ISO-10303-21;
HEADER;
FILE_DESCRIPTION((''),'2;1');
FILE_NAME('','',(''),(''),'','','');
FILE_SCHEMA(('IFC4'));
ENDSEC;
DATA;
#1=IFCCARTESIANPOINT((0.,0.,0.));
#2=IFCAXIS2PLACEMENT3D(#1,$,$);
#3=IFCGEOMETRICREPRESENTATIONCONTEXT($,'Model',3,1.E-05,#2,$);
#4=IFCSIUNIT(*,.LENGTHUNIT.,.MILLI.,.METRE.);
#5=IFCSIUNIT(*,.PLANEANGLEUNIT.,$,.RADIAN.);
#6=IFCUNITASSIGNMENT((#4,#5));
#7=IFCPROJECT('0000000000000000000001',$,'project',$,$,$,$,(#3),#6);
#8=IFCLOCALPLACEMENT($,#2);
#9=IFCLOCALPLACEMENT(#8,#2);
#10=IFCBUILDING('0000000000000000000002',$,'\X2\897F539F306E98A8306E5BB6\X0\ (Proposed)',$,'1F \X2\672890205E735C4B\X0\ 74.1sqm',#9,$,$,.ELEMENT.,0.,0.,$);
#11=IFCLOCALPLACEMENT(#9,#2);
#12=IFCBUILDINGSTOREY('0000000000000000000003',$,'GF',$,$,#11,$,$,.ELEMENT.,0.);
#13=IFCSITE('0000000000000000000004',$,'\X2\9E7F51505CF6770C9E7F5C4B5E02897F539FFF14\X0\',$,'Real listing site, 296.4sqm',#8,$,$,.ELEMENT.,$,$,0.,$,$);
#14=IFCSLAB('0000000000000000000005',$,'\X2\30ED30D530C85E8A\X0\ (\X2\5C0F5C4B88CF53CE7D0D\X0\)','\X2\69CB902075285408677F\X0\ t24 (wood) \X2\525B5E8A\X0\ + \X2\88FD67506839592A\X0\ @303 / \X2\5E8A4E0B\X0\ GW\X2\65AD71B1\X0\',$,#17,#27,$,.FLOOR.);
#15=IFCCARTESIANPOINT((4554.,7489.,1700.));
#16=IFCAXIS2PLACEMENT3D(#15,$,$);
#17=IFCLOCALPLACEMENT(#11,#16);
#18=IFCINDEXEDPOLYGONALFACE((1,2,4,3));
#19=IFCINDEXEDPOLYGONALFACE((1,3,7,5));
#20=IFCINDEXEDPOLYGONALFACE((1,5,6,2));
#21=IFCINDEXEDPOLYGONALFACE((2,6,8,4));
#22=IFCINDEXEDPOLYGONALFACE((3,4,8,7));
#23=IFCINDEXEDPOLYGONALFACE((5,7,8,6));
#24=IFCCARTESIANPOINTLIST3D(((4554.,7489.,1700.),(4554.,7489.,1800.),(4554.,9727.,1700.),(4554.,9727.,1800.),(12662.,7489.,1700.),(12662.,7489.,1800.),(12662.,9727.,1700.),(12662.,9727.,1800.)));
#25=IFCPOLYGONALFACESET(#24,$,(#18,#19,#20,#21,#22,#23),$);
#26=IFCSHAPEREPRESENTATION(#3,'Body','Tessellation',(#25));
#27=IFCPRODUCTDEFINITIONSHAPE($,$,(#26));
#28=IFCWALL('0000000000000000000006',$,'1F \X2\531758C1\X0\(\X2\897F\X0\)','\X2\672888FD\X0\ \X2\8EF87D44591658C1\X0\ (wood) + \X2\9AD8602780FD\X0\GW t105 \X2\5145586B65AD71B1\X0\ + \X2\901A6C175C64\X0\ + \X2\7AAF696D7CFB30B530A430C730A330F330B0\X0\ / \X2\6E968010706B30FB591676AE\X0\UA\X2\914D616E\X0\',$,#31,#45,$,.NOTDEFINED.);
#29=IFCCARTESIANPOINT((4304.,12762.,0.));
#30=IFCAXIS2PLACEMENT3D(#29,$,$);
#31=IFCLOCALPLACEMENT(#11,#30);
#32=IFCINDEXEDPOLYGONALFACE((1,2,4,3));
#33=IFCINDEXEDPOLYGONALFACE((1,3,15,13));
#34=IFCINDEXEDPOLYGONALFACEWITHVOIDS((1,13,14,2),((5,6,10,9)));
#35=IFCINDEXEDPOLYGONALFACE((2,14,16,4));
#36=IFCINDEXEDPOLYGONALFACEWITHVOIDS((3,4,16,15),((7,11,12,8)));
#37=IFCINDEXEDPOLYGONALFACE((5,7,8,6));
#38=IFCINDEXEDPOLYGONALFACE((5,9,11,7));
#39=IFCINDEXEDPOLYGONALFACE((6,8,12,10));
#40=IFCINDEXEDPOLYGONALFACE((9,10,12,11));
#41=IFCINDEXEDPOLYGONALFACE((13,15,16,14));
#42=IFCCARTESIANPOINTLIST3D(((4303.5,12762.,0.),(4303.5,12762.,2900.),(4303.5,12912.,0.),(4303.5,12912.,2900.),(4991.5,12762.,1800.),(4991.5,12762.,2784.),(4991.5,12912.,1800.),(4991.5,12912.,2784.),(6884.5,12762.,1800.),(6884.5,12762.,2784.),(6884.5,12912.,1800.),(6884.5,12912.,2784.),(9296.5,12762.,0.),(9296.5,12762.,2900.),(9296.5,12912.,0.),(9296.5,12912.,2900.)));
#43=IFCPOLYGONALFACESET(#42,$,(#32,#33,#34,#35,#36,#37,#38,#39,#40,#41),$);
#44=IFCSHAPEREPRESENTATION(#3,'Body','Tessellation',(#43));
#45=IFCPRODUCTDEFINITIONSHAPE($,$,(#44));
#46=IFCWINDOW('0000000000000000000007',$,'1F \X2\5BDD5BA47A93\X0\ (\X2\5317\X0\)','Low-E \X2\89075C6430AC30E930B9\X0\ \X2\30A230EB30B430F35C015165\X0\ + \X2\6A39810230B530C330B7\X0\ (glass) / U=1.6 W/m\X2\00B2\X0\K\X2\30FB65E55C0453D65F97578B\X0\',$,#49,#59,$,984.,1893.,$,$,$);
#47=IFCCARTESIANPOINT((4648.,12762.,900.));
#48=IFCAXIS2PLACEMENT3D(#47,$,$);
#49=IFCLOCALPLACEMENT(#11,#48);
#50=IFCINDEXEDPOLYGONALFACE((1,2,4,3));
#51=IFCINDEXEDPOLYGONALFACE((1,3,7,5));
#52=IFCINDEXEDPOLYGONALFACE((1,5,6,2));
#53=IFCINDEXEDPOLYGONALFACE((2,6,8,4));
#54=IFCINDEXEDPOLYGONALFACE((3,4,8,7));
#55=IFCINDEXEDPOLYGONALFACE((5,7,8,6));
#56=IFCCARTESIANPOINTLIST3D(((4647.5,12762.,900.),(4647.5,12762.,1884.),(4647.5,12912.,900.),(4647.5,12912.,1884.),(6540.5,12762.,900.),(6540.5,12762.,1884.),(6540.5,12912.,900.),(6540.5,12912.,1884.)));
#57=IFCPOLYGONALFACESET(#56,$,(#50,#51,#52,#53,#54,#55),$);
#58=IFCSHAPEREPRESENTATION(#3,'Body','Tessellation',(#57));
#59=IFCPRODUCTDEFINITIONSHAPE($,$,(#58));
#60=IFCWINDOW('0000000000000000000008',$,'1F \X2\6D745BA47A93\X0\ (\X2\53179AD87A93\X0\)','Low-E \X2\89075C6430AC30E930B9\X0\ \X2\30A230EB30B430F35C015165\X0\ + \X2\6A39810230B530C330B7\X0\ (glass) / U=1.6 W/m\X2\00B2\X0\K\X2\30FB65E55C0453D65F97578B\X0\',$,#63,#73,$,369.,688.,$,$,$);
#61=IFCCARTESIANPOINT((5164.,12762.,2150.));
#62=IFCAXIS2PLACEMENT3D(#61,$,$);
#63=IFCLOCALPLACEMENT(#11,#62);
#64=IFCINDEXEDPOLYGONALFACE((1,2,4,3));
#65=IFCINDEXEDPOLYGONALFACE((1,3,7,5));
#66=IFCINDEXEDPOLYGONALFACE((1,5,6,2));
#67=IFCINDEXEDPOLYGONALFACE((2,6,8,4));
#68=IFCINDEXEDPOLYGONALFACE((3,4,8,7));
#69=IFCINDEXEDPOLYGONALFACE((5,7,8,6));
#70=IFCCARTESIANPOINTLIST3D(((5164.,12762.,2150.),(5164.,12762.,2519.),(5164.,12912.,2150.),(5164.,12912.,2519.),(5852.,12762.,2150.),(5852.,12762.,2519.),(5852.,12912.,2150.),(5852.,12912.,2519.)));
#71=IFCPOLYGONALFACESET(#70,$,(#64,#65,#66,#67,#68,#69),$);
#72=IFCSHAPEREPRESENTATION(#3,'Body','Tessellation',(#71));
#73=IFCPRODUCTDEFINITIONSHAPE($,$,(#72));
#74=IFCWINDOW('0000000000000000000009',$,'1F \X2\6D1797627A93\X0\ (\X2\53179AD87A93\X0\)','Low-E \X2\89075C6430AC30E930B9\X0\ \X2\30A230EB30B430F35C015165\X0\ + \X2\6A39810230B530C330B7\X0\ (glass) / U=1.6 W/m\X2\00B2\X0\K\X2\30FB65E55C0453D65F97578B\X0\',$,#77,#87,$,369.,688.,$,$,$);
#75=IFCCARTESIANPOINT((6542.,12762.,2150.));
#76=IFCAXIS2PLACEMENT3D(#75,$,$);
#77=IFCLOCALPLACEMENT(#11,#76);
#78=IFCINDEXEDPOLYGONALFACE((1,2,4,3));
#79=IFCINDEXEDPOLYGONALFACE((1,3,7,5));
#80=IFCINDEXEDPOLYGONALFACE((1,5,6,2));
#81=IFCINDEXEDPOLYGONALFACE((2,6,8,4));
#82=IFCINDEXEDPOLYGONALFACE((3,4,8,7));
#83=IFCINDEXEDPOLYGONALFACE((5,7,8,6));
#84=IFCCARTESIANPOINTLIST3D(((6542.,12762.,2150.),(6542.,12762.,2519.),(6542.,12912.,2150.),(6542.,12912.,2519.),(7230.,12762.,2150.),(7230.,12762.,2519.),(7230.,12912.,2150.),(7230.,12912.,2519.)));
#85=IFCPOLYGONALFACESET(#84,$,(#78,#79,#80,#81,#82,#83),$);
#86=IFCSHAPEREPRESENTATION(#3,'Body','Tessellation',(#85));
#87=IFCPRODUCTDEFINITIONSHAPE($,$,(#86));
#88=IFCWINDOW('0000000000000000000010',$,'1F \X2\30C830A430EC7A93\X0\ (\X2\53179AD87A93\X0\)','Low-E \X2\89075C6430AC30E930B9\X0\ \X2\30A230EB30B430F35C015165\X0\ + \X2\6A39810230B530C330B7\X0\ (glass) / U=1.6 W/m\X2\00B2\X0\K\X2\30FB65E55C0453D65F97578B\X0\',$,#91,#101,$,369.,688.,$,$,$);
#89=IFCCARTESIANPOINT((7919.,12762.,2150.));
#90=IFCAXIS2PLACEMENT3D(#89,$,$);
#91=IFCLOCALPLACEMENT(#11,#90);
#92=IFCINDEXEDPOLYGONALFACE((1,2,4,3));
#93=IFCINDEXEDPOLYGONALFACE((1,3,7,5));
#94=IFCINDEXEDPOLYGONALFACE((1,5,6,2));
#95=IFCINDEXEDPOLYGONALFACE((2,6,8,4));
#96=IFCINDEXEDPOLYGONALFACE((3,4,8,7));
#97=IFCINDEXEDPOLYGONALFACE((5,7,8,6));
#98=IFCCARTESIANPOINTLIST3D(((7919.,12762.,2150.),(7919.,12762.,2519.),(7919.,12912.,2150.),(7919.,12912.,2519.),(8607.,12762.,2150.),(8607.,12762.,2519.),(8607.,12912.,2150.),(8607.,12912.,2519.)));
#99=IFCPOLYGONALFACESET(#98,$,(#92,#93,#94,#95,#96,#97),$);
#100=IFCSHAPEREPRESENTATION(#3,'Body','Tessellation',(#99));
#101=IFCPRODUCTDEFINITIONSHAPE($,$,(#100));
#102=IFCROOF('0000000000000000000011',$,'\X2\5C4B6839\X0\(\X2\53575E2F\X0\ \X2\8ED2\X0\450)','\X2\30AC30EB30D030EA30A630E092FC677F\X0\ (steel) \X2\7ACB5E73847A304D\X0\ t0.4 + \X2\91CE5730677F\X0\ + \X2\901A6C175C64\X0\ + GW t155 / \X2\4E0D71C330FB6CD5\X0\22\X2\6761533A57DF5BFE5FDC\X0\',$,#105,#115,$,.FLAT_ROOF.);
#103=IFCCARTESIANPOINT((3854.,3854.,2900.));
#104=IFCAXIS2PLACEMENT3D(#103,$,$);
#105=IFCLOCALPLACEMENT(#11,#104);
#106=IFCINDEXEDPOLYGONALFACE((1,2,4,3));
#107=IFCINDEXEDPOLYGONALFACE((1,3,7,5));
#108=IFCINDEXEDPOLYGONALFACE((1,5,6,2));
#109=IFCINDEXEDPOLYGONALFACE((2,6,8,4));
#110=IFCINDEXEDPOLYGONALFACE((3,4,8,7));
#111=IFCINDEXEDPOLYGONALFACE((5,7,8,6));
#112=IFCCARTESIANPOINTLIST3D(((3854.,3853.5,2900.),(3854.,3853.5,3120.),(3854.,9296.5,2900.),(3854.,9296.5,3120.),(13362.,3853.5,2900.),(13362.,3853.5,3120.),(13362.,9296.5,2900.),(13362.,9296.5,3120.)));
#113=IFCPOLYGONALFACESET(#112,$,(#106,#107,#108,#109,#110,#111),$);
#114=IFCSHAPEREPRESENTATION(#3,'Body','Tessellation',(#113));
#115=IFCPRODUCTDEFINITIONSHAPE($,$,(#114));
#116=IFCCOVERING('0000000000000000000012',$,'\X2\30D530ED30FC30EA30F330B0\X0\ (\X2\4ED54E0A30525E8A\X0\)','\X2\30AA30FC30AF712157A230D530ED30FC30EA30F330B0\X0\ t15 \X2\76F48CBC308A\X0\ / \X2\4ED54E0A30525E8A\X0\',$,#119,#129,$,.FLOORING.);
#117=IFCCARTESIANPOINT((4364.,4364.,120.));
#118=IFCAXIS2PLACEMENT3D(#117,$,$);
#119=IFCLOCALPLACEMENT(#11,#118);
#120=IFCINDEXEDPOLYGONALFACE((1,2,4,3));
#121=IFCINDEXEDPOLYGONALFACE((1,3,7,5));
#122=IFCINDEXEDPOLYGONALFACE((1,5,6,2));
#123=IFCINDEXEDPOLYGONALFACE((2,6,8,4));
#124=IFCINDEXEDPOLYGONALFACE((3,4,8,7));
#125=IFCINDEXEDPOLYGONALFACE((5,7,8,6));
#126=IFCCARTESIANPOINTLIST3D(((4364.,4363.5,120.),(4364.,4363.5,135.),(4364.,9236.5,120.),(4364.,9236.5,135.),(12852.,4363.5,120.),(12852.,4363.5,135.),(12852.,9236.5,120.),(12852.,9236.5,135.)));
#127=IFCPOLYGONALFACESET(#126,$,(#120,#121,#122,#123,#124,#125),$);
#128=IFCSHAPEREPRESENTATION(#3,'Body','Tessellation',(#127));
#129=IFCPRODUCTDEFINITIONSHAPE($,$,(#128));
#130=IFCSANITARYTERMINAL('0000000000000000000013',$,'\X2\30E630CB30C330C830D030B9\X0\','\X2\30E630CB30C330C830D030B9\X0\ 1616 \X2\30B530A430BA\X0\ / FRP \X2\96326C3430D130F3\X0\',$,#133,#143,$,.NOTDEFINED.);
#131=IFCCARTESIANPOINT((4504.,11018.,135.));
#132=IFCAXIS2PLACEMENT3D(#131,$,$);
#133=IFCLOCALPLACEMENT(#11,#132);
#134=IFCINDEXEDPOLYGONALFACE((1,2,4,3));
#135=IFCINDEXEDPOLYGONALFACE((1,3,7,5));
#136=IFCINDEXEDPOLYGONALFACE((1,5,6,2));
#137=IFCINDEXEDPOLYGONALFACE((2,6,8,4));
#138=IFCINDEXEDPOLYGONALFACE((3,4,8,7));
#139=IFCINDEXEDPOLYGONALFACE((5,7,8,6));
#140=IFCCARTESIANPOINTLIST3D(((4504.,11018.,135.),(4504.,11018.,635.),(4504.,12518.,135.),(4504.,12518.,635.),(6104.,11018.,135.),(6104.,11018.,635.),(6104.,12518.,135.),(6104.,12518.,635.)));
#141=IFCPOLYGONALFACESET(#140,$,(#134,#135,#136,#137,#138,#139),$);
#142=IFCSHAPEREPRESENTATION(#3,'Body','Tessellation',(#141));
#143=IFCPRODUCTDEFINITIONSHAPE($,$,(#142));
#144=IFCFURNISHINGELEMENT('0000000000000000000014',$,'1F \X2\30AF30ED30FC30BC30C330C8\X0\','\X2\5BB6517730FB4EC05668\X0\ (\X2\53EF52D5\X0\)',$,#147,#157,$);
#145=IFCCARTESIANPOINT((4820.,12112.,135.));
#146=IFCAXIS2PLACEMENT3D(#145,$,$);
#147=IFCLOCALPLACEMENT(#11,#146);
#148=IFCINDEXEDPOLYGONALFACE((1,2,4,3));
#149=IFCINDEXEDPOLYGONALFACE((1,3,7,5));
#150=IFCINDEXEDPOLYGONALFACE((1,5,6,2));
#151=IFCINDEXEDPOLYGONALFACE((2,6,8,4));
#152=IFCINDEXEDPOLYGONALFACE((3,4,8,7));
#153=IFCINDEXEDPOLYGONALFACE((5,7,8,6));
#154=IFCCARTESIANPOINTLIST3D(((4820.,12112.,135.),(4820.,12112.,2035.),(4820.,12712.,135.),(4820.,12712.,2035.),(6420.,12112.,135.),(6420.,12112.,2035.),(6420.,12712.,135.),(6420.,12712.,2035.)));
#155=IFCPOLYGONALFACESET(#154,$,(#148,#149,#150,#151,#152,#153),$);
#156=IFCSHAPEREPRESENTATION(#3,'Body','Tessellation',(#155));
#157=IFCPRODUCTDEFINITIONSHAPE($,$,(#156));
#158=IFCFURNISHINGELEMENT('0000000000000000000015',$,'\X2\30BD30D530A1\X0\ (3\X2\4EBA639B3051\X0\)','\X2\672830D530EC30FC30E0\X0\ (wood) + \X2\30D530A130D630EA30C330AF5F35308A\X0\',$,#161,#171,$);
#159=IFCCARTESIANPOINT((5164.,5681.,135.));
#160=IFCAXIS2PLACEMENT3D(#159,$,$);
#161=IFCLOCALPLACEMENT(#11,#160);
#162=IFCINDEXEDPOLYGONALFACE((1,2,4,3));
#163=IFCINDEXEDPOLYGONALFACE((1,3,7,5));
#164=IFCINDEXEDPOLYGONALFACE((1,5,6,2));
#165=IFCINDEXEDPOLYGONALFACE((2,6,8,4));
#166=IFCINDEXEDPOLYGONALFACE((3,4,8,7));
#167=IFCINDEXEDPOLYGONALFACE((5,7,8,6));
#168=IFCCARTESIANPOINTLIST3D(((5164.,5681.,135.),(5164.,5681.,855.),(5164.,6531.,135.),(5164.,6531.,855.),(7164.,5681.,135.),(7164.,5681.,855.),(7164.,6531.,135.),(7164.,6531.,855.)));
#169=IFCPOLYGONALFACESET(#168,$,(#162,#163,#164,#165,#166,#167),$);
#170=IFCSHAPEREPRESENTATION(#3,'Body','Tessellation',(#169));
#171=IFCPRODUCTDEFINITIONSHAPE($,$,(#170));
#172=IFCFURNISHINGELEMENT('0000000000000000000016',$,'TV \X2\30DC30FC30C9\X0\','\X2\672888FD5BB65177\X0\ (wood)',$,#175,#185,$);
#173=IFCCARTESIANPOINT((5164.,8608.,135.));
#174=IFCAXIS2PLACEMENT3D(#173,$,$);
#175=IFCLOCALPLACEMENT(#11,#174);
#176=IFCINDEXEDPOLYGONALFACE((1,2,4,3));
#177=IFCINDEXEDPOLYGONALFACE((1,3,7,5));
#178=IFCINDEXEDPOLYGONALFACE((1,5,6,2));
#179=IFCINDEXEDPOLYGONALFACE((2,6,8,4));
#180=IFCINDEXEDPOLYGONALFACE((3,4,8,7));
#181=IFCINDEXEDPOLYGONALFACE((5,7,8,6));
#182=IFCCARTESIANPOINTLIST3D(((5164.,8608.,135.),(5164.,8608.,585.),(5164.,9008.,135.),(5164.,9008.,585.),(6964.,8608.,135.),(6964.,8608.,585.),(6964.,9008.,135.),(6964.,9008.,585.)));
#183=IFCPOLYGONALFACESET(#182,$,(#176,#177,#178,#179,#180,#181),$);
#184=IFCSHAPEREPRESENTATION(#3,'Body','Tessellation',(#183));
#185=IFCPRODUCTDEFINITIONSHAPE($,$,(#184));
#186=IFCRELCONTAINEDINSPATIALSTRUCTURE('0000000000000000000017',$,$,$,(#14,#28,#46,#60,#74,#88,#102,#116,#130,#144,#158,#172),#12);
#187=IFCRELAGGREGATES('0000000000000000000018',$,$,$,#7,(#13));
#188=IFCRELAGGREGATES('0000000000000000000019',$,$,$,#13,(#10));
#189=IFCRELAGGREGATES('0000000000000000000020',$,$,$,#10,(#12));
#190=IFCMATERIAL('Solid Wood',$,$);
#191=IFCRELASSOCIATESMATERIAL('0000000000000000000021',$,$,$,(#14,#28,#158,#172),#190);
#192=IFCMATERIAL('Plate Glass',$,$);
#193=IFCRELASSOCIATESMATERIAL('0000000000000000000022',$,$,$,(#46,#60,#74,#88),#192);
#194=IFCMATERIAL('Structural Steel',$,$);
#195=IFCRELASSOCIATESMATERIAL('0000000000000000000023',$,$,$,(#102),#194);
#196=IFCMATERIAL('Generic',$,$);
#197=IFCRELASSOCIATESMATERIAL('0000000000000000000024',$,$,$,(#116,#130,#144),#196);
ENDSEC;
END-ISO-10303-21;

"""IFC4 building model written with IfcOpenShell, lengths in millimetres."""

from ifc_helpers import new_model, si_unit, frame, frame_2d, origin, place, context, project, spatial, rectangle, extrude, material, element, fill, save


model = new_model("IFC4")

# Units and contexts
model_context = context("Model", 3, precision=1e-05, world=origin())
ifc_project = project(units=[si_unit("LENGTHUNIT", "METRE", prefix="MILLI"), si_unit("PLANEANGLEUNIT", "RADIAN")], contexts=[model_context])

# Site, building, storey
site_placement = place(None, origin())
site = spatial("IfcSite", under=ifc_project, at=site_placement, Name="鹿児島県鹿屋市西原４", ObjectType="Real listing site, 296.4sqm", CompositionType="ELEMENT", RefElevation=0.0)
building_placement = place(site_placement, origin())
building = spatial("IfcBuilding", under=site, at=building_placement, Name="西原の風の家 (Proposed)", ObjectType="1F 木造平屋 74.1sqm", CompositionType="ELEMENT", ElevationOfRefHeight=0.0, ElevationOfTerrain=0.0)
storey_placement = place(building_placement, origin())
storey = spatial("IfcBuildingStorey", under=building, at=storey_placement, Name="GF", CompositionType="ELEMENT", Elevation=0.0)

# Slab
ifc_material_1 = material(Name="Solid Wood")
slab_1_placement = place(storey_placement, frame((4554.0, 7489.0, 1700.0)))
element("IfcSlab", 1, at=slab_1_placement, inside=storey, material=ifc_material_1, Name="ロフト床 (小屋裏収納)", Description="構造用合板 t24 (wood) 剛床 + 製材根太 @303 / 床下 GW断熱", PredefinedType="FLOOR", context=model_context, shape_type="SweptSolid", body=[
    extrude(rectangle(XDim=8108.0, YDim=2238.0, at=frame_2d((4054.0, 1119.0))), frame((4554.0, 7489.0, 1700.0)), (0.0, 0.0, 1.0), 100.0),
])

# Shared definitions
ifc_material_2 = material(Name="Plate Glass")

# Wall, openings, windows
wall_1_placement = place(storey_placement, frame((4304.0, 12762.0, 0.0)))
wall_1 = element("IfcWall", 2, at=wall_1_placement, inside=storey, material=ifc_material_1, Name="1F 北壁(西)", Description="木製 軸組外壁 (wood) + 高性能GW t105 充填断熱 + 通気層 + 窯業系サイディング / 準耐火・外皮UA配慮", PredefinedType="NOTDEFINED", context=model_context, shape_type="SweptSolid", body=[
    extrude(rectangle(XDim=4993.0, YDim=150.0, at=frame_2d((2496.0, 75.0))), frame((4304.0, 12762.0, 0.0)), (0.0, 0.0, 1.0), 2900.0),
])
opening_1_placement = place(storey_placement, frame((4648.0, 12762.0, 900.0)))
opening_1 = element("IfcOpeningElement", 3, at=opening_1_placement, cuts=wall_1, PredefinedType="NOTDEFINED", context=model_context, shape_type="SweptSolid", body=[
    extrude(rectangle(XDim=1893.0, YDim=150.0, at=frame_2d((946.0, 75.0))), frame((4648.0, 12762.0, 900.0)), (0.0, 0.0, 1.0), 984.0),
])
opening_2_placement = place(storey_placement, frame((5164.0, 12762.0, 2150.0)))
opening_2 = element("IfcOpeningElement", 4, at=opening_2_placement, cuts=wall_1, PredefinedType="NOTDEFINED", context=model_context, shape_type="SweptSolid", body=[
    extrude(rectangle(XDim=688.0, YDim=150.0, at=frame_2d((344.0, 75.0))), frame((5164.0, 12762.0, 2150.0)), (0.0, 0.0, 1.0), 369.0),
])
opening_3_placement = place(storey_placement, frame((6542.0, 12762.0, 2150.0)))
opening_3 = element("IfcOpeningElement", 5, at=opening_3_placement, cuts=wall_1, PredefinedType="NOTDEFINED", context=model_context, shape_type="SweptSolid", body=[
    extrude(rectangle(XDim=688.0, YDim=150.0, at=frame_2d((344.0, 75.0))), frame((6542.0, 12762.0, 2150.0)), (0.0, 0.0, 1.0), 369.0),
])
opening_4_placement = place(storey_placement, frame((7919.0, 12762.0, 2150.0)))
opening_4 = element("IfcOpeningElement", 6, at=opening_4_placement, cuts=wall_1, PredefinedType="NOTDEFINED", context=model_context, shape_type="SweptSolid", body=[
    extrude(rectangle(XDim=688.0, YDim=150.0, at=frame_2d((344.0, 75.0))), frame((7919.0, 12762.0, 2150.0)), (0.0, 0.0, 1.0), 369.0),
])
window_1_placement = place(storey_placement, frame((4648.0, 12762.0, 900.0)))
window_1 = element("IfcWindow", 7, at=window_1_placement, inside=storey, material=ifc_material_2, Name="1F 寝室窓 (北)", Description="Low-E 複層ガラス アルゴン封入 + 樹脂サッシ (glass) / U=1.6 W/m²K・日射取得型", OverallHeight=984.0, OverallWidth=1893.0, context=model_context, shape_type="SweptSolid", body=[
    extrude(rectangle(XDim=1893.0, YDim=150.0, at=frame_2d((946.0, 75.0))), frame((4648.0, 12762.0, 900.0)), (0.0, 0.0, 1.0), 984.0),
])
fill(opening_1, window_1)
window_2_placement = place(storey_placement, frame((5164.0, 12762.0, 2150.0)))
window_2 = element("IfcWindow", 8, at=window_2_placement, inside=storey, material=ifc_material_2, Name="1F 浴室窓 (北高窓)", Description="Low-E 複層ガラス アルゴン封入 + 樹脂サッシ (glass) / U=1.6 W/m²K・日射取得型", OverallHeight=369.0, OverallWidth=688.0, context=model_context, shape_type="SweptSolid", body=[
    extrude(rectangle(XDim=688.0, YDim=150.0, at=frame_2d((344.0, 75.0))), frame((5164.0, 12762.0, 2150.0)), (0.0, 0.0, 1.0), 369.0),
])
fill(opening_2, window_2)
window_3_placement = place(storey_placement, frame((6542.0, 12762.0, 2150.0)))
window_3 = element("IfcWindow", 9, at=window_3_placement, inside=storey, material=ifc_material_2, Name="1F 洗面窓 (北高窓)", Description="Low-E 複層ガラス アルゴン封入 + 樹脂サッシ (glass) / U=1.6 W/m²K・日射取得型", OverallHeight=369.0, OverallWidth=688.0, context=model_context, shape_type="SweptSolid", body=[
    extrude(rectangle(XDim=688.0, YDim=150.0, at=frame_2d((344.0, 75.0))), frame((6542.0, 12762.0, 2150.0)), (0.0, 0.0, 1.0), 369.0),
])
fill(opening_3, window_3)
window_4_placement = place(storey_placement, frame((7919.0, 12762.0, 2150.0)))
window_4 = element("IfcWindow", 10, at=window_4_placement, inside=storey, material=ifc_material_2, Name="1F トイレ窓 (北高窓)", Description="Low-E 複層ガラス アルゴン封入 + 樹脂サッシ (glass) / U=1.6 W/m²K・日射取得型", OverallHeight=369.0, OverallWidth=688.0, context=model_context, shape_type="SweptSolid", body=[
    extrude(rectangle(XDim=688.0, YDim=150.0, at=frame_2d((344.0, 75.0))), frame((7919.0, 12762.0, 2150.0)), (0.0, 0.0, 1.0), 369.0),
])
fill(opening_4, window_4)

# Roof
ifc_material_3 = material(Name="Structural Steel")
roof_1_placement = place(storey_placement, frame((3854.0, 3854.0, 2900.0)))
element("IfcRoof", 11, at=roof_1_placement, inside=storey, material=ifc_material_3, Name="屋根(南帯 軒450)", Description="ガルバリウム鋼板 (steel) 立平葺き t0.4 + 野地板 + 通気層 + GW t155 / 不燃・法22条区域対応", PredefinedType="FLAT_ROOF", context=model_context, shape_type="SweptSolid", body=[
    extrude(rectangle(XDim=9508.0, YDim=5443.0, at=frame_2d((4754.0, 2721.0))), frame((3854.0, 3854.0, 2900.0)), (0.0, 0.0, 1.0), 220.0),
])

# Covering
ifc_material_4 = material(Name="Generic")
covering_1_placement = place(storey_placement, frame((4364.0, 4364.0, 120.0)))
element("IfcCovering", 12, at=covering_1_placement, inside=storey, material=ifc_material_4, Name="フローリング (仕上げ床)", Description="オーク無垢フローリング t15 直貼り / 仕上げ床", PredefinedType="FLOORING", context=model_context, shape_type="SweptSolid", body=[
    extrude(rectangle(XDim=8488.0, YDim=4873.0, at=frame_2d((4244.0, 2436.0))), frame((4364.0, 4364.0, 120.0)), (0.0, 0.0, 1.0), 15.0),
])

# Sanitary terminal
sanitary_terminal_placement = place(storey_placement, frame((4504.0, 11018.0, 135.0)))
element("IfcSanitaryTerminal", 13, at=sanitary_terminal_placement, inside=storey, material=ifc_material_4, Name="ユニットバス", Description="ユニットバス 1616 サイズ / FRP 防水パン", PredefinedType="NOTDEFINED", context=model_context, shape_type="SweptSolid", body=[
    extrude(rectangle(XDim=1600.0, YDim=1500.0, at=frame_2d((800.0, 750.0))), frame((4504.0, 11018.0, 135.0)), (0.0, 0.0, 1.0), 500.0),
])

# Furnishing elements
furnishing_1_placement = place(storey_placement, frame((4820.0, 12112.0, 135.0)))
element("IfcFurnishingElement", 14, at=furnishing_1_placement, inside=storey, material=ifc_material_4, Name="1F クローゼット", Description="家具・什器 (可動)", context=model_context, shape_type="SweptSolid", body=[
    extrude(rectangle(XDim=1600.0, YDim=600.0, at=frame_2d((800.0, 300.0))), frame((4820.0, 12112.0, 135.0)), (0.0, 0.0, 1.0), 1900.0),
])
furnishing_2_placement = place(storey_placement, frame((5164.0, 5681.0, 135.0)))
element("IfcFurnishingElement", 15, at=furnishing_2_placement, inside=storey, material=ifc_material_1, Name="ソファ (3人掛け)", Description="木フレーム (wood) + ファブリック張り", context=model_context, shape_type="SweptSolid", body=[
    extrude(rectangle(XDim=2000.0, YDim=850.0, at=frame_2d((1000.0, 425.0))), frame((5164.0, 5681.0, 135.0)), (0.0, 0.0, 1.0), 720.0),
])
furnishing_3_placement = place(storey_placement, frame((5164.0, 8608.0, 135.0)))
element("IfcFurnishingElement", 16, at=furnishing_3_placement, inside=storey, material=ifc_material_1, Name="TV ボード", Description="木製家具 (wood)", context=model_context, shape_type="SweptSolid", body=[
    extrude(rectangle(XDim=1800.0, YDim=400.0, at=frame_2d((900.0, 200.0))), frame((5164.0, 8608.0, 135.0)), (0.0, 0.0, 1.0), 450.0),
])

save(model, "model.ifc")
